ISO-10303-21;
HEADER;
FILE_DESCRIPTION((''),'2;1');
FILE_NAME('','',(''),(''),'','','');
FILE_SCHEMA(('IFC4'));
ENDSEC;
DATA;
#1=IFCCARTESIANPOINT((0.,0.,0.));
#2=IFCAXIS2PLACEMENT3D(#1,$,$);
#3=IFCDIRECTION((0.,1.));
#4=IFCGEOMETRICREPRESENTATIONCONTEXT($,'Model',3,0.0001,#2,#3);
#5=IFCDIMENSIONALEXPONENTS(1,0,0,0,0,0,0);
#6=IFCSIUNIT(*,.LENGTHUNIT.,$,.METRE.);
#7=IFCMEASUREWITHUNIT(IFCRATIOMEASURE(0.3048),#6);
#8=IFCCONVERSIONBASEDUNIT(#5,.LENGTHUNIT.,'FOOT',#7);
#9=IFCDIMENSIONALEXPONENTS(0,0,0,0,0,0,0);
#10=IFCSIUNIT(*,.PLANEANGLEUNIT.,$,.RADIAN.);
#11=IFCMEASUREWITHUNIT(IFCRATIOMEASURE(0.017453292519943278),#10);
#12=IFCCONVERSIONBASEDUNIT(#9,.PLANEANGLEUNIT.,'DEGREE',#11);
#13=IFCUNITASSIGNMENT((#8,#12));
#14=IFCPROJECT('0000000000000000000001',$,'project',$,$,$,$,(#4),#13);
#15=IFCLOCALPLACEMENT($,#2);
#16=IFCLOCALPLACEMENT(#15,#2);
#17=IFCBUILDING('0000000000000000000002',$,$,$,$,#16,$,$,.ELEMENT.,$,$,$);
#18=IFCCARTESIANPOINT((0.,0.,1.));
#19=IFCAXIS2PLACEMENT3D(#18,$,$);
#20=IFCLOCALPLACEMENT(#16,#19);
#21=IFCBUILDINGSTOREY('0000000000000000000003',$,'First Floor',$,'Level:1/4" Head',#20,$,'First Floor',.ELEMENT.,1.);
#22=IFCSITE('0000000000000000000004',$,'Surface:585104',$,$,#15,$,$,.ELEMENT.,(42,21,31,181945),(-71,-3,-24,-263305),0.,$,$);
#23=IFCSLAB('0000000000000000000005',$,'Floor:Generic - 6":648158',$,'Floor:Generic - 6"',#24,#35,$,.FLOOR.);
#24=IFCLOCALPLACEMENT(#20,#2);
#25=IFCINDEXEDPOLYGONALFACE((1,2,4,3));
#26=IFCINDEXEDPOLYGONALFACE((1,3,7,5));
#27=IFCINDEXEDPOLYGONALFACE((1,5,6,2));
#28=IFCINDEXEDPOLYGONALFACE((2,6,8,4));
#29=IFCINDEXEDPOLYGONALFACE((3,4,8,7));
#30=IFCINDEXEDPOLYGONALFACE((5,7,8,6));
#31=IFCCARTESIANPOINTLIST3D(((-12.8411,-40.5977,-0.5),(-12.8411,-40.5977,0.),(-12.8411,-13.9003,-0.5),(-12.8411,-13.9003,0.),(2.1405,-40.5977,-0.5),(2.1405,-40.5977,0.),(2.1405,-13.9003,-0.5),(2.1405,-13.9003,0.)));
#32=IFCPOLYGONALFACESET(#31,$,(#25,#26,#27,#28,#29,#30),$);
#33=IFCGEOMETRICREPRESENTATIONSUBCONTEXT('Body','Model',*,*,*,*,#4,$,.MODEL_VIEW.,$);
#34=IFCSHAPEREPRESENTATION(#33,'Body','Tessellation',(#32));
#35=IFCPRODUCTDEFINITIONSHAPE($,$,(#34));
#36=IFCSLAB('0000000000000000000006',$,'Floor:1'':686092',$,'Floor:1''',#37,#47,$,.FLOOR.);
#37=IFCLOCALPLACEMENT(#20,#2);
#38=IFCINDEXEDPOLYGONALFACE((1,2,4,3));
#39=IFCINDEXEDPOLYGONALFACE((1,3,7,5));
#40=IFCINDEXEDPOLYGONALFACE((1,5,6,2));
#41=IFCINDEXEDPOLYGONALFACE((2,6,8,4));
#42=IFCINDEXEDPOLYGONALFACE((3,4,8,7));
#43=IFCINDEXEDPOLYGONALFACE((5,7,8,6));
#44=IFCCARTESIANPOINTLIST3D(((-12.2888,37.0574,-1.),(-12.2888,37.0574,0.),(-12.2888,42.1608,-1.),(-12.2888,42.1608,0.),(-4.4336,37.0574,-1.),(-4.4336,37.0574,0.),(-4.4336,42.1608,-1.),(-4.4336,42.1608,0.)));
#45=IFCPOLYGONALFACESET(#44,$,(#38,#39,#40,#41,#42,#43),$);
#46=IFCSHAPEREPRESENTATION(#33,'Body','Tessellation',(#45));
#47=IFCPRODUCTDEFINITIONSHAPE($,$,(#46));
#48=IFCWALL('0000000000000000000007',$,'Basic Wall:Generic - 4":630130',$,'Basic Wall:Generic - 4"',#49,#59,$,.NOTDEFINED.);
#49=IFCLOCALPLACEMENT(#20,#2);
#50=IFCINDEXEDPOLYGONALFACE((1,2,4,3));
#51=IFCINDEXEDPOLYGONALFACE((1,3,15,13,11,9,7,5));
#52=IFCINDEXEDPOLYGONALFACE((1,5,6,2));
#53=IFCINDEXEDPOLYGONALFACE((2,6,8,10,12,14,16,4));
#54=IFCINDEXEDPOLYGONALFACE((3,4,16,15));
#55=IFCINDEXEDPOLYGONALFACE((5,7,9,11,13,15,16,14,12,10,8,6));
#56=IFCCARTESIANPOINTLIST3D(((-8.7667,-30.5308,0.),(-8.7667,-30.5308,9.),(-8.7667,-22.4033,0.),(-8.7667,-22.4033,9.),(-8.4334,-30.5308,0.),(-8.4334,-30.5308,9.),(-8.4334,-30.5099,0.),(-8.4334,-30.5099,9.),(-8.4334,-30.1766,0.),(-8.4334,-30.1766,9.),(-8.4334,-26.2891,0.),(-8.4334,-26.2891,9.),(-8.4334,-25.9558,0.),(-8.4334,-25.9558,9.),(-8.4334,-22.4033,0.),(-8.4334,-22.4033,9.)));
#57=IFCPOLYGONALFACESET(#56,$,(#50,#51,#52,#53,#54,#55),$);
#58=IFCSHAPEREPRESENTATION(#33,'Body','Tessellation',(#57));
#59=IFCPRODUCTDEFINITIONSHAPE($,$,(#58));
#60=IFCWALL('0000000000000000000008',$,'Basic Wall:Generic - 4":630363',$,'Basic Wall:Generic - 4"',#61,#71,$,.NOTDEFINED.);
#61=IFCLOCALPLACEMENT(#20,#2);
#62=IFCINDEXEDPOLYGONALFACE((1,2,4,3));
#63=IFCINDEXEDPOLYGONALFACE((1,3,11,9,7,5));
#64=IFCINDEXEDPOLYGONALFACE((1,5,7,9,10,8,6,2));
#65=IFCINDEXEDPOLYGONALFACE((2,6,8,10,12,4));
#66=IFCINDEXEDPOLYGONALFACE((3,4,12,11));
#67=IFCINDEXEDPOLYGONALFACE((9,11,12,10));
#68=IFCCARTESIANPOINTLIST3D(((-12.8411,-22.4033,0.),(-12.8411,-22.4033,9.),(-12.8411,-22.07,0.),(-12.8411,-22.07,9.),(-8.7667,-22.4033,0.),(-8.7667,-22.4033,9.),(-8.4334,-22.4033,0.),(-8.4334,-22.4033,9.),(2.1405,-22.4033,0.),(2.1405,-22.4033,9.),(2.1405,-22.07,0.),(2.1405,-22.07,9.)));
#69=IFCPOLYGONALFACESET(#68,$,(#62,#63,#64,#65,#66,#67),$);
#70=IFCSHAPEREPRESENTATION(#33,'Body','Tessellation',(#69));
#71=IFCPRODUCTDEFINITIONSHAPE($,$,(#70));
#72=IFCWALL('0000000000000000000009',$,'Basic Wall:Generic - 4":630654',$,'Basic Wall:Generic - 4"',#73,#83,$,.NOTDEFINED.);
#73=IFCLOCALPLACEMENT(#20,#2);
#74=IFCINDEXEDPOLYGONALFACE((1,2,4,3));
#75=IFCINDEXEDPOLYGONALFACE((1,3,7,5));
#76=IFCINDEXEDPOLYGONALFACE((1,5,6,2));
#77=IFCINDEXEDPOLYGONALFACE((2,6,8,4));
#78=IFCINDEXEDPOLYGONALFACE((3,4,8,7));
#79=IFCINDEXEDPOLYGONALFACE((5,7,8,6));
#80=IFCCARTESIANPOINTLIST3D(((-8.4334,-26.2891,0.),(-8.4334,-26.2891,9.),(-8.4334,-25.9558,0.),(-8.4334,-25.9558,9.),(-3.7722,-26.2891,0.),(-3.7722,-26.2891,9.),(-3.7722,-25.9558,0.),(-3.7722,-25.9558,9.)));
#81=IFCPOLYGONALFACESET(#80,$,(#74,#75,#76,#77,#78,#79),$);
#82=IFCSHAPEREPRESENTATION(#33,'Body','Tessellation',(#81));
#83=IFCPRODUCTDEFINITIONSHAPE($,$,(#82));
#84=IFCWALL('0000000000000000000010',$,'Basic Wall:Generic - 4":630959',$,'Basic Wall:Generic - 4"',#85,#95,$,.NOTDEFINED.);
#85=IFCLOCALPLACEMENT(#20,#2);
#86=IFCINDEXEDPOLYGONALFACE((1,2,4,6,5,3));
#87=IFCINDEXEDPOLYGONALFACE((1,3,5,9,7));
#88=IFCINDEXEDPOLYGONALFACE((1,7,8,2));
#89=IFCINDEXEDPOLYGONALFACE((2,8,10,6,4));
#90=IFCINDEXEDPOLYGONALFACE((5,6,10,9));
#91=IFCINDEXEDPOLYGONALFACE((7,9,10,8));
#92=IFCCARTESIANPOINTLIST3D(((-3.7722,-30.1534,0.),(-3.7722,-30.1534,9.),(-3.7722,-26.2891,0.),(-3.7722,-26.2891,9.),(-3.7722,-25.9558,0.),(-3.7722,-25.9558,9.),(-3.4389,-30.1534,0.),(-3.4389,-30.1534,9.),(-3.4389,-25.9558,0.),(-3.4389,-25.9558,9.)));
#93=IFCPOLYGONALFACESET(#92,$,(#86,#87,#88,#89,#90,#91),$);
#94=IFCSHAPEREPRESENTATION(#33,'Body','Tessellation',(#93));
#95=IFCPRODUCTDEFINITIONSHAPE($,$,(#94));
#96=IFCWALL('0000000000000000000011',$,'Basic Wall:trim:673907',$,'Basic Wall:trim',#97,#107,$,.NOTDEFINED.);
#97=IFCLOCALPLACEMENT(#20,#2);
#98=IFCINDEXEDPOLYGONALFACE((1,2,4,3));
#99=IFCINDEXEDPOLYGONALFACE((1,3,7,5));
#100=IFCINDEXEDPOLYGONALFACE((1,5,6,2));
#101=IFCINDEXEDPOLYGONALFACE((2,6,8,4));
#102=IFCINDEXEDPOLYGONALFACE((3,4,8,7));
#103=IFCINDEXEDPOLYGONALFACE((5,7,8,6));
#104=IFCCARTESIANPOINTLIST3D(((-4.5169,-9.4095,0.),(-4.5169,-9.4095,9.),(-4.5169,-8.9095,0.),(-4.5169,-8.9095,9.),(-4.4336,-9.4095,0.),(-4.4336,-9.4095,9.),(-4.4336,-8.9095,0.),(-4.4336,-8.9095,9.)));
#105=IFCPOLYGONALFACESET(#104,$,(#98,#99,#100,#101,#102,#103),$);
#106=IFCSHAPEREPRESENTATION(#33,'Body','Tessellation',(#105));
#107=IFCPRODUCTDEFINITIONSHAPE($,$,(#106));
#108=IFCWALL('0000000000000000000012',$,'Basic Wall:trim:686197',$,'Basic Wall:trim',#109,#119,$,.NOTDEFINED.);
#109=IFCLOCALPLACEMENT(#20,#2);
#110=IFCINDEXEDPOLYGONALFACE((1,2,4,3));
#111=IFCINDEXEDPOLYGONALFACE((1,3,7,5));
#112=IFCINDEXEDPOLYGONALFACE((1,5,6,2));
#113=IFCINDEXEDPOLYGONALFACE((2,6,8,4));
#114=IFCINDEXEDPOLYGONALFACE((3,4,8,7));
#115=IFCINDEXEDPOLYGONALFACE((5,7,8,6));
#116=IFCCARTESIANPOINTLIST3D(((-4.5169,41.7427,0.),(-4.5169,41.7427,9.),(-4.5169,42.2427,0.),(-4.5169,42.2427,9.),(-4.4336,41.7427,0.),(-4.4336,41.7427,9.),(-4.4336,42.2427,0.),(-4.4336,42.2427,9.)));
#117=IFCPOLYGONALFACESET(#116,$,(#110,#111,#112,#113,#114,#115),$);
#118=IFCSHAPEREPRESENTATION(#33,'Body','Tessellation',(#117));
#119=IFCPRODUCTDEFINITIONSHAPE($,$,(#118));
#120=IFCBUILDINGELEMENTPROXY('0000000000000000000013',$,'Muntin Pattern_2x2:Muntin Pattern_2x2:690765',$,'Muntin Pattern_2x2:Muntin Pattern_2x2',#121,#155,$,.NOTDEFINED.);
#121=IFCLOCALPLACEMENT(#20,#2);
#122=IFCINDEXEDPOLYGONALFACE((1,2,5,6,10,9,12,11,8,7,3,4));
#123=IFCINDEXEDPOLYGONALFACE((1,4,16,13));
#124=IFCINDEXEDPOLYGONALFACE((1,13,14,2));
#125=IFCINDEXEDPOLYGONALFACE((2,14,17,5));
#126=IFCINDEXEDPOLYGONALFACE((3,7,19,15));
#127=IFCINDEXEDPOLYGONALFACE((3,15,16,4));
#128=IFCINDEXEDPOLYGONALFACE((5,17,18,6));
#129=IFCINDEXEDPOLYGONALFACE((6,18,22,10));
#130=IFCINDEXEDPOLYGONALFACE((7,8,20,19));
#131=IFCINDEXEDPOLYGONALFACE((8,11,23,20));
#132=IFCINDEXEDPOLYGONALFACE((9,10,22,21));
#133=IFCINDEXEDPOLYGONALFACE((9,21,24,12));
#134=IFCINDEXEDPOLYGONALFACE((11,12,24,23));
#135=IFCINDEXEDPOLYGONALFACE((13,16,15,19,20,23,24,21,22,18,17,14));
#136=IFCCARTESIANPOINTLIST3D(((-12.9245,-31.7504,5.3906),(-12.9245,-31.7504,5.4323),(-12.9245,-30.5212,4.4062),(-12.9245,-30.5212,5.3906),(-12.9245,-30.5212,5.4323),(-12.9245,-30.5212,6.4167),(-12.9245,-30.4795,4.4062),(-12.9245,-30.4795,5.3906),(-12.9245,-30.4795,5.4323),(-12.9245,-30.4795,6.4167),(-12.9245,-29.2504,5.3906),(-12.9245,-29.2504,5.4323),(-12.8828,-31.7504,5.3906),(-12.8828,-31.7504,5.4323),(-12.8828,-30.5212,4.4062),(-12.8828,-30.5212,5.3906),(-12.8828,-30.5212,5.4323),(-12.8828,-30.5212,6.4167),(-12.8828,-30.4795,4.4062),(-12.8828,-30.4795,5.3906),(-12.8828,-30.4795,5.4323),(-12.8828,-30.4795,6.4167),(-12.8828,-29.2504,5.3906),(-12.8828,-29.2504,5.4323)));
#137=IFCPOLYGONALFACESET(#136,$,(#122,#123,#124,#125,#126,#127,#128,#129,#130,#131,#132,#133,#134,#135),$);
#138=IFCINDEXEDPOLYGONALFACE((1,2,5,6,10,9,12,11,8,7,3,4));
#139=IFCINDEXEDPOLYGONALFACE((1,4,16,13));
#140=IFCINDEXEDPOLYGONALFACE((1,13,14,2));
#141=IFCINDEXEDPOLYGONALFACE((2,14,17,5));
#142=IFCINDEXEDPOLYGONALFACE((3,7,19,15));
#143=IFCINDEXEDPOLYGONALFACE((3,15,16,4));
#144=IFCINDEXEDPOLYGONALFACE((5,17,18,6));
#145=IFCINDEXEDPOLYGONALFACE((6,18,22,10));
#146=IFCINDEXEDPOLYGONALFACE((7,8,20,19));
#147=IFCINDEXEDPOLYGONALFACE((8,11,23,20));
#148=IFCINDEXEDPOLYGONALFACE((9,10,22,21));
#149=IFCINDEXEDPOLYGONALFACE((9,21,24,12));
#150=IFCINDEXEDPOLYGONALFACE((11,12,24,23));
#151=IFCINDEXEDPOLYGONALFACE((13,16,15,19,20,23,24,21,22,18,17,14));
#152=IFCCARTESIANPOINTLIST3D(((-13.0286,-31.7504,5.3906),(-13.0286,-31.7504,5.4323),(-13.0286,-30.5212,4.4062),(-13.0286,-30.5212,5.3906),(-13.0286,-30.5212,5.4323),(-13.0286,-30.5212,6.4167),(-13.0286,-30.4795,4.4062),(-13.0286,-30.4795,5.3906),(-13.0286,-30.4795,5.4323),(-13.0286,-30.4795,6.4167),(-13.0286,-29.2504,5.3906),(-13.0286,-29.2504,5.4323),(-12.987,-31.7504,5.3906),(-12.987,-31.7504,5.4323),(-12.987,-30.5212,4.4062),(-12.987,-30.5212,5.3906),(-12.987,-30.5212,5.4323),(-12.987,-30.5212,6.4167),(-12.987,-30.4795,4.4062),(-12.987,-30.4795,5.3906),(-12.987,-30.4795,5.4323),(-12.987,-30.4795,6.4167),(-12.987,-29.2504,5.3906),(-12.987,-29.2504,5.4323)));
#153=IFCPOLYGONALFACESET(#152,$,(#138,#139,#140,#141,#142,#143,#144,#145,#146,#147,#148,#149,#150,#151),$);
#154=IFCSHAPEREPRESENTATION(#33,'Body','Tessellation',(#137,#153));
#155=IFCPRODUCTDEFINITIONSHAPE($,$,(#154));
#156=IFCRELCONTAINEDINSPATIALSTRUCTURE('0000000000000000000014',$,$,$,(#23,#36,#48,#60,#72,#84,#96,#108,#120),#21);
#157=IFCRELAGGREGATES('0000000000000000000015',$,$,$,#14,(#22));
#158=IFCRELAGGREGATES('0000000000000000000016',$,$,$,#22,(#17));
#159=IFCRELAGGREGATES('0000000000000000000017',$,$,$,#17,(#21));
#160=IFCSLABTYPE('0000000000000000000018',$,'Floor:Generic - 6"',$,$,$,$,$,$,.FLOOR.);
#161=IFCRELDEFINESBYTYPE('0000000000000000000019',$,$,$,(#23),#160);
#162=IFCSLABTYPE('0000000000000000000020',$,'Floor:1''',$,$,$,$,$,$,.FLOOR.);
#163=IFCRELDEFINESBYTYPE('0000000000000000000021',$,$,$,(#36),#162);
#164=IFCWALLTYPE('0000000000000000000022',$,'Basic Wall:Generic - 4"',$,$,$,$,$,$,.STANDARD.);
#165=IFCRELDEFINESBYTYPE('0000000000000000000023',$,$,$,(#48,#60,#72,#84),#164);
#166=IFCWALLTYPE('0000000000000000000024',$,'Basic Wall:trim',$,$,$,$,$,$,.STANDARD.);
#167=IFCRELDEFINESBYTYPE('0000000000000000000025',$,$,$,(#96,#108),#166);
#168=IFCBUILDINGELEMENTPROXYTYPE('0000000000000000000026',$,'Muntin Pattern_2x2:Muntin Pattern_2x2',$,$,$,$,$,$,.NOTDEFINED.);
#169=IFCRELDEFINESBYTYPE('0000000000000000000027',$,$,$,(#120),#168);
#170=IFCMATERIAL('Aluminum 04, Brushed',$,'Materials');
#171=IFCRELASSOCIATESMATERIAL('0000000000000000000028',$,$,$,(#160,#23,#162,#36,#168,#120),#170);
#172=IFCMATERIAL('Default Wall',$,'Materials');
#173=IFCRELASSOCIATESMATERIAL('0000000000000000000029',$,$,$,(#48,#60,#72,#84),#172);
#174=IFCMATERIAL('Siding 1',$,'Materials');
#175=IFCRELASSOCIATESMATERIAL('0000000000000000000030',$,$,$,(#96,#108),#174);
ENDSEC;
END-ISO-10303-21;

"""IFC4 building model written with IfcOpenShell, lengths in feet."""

from ifc_helpers import new_model, entity, si_unit, converted_unit, direction, frame, origin, place, context, subcontext, project, spatial, indexed_curve, outline, extrude, source, transform, mapped, material, type_object, type_shapes, element, save


model = new_model("IFC4")

# Units and contexts
model_context = context("Model", 3, precision=0.0001, world=origin(), true_north=direction((0.0, 1.0)))
body_context = subcontext(model_context, "Body", "Model", "MODEL_VIEW")
ifc_project = project(units=[converted_unit("LENGTHUNIT", "FOOT", entity("IfcRatioMeasure", 0.3048), si_unit("LENGTHUNIT", "METRE"), dimensions=[1, 0, 0, 0, 0, 0, 0]), converted_unit("PLANEANGLEUNIT", "DEGREE", entity("IfcRatioMeasure", 0.017453292519943278), si_unit("PLANEANGLEUNIT", "RADIAN"), dimensions=[0, 0, 0, 0, 0, 0, 0])], contexts=[model_context])

# Site, building, storey
site_placement = place(None, origin())
site = spatial("IfcSite", under=ifc_project, at=site_placement, Name="Surface:585104", CompositionType="ELEMENT", RefLatitude=(42, 21, 31, 181945), RefLongitude=(-71, -3, -24, -263305), RefElevation=0.0)
building_placement = place(site_placement, origin())
building = spatial("IfcBuilding", under=site, at=building_placement, CompositionType="ELEMENT")
storey_placement = place(building_placement, frame((0.0, 0.0, 1.0)))
storey = spatial("IfcBuildingStorey", under=building, at=storey_placement, Name="First Floor", ObjectType="Level:1/4\" Head", LongName="First Floor", CompositionType="ELEMENT", Elevation=1.0)

# Shared definitions
ifc_material_1 = material(Name="Aluminum 04, Brushed", Category="Materials")

# Slabs
slab_type_1 = type_object("IfcSlabType", Name="Floor:Generic - 6\"", PredefinedType="FLOOR", material=ifc_material_1)
slab_1_placement = place(storey_placement, origin())
element("IfcSlab", 1, at=slab_1_placement, inside=storey, type_object=slab_type_1, material=ifc_material_1, Name="Floor:Generic - 6\":648158", ObjectType="Floor:Generic - 6\"", PredefinedType="FLOOR", context=body_context, shape_type="SweptSolid", body=[
    extrude(outline(indexed_curve([(-13.3487, -7.4908), (13.3487, -7.4908), (13.3487, 7.4908), (-13.3487, 7.4908), (-13.3487, -7.4908)], self_intersect=False)), frame((-5.3503, -27.249, 0.0), z_axis=(0.0, 0.0, -1.0), x_axis=(0.0, 1.0, 0.0)), (0.0, 0.0, 1.0), 0.5),
])
slab_type_2 = type_object("IfcSlabType", Name="Floor:1'", PredefinedType="FLOOR", material=ifc_material_1)
slab_2_placement = place(storey_placement, origin())
element("IfcSlab", 2, at=slab_2_placement, inside=storey, type_object=slab_type_2, material=ifc_material_1, Name="Floor:1':686092", ObjectType="Floor:1'", PredefinedType="FLOOR", context=body_context, shape_type="SweptSolid", body=[
    extrude(outline(indexed_curve([(-2.5517, -3.9276), (2.5517, -3.9276), (2.5517, 3.9276), (-2.5517, 3.9276), (-2.5517, -3.9276)], self_intersect=False)), frame((-8.3612, 39.6091, 0.0), z_axis=(0.0, 0.0, -1.0), x_axis=(0.0, 1.0, 0.0)), (0.0, 0.0, 1.0), 1.0),
])

# Walls
ifc_material_2 = material(Name="Default Wall", Category="Materials")
wall_type_1 = type_object("IfcWallType", Name="Basic Wall:Generic - 4\"", PredefinedType="STANDARD")
wall_1_placement = place(storey_placement, frame((-8.6001, -30.5308, 0.0), z_axis=(0.0, 0.0, 1.0), x_axis=(0.0, 1.0, 0.0)))
element("IfcWall", 3, at=wall_1_placement, inside=storey, type_object=wall_type_1, material=ifc_material_2, Name="Basic Wall:Generic - 4\":630130", ObjectType="Basic Wall:Generic - 4\"", PredefinedType="NOTDEFINED", context=body_context, shape_type="SweptSolid", body=[
    extrude(outline(indexed_curve([(8.1274, -0.1667), (8.1274, 0.1667), (0.0, 0.1667), (0.0, -0.1667), (0.0208, -0.1667), (0.3542, -0.1667), (4.2416, -0.1667), (4.575, -0.1667), (8.1274, -0.1667)], self_intersect=False)), origin(), (0.0, 0.0, 1.0), 9.0),
])
wall_2_placement = place(storey_placement, frame((-12.8411, -22.2367, 0.0)))
element("IfcWall", 4, at=wall_2_placement, inside=storey, type_object=wall_type_1, material=ifc_material_2, Name="Basic Wall:Generic - 4\":630363", ObjectType="Basic Wall:Generic - 4\"", PredefinedType="NOTDEFINED", context=body_context, shape_type="SweptSolid", body=[
    extrude(outline(indexed_curve([(14.9816, -0.1667), (14.9816, 0.1667), (0.0, 0.1667), (0.0, -0.1667), (4.0744, -0.1667), (4.4077, -0.1667), (14.9816, -0.1667)], self_intersect=False)), origin(), (0.0, 0.0, 1.0), 9.0),
])
wall_3_placement = place(storey_placement, frame((-8.4334, -26.1225, 0.0)))
element("IfcWall", 5, at=wall_3_placement, inside=storey, type_object=wall_type_1, material=ifc_material_2, Name="Basic Wall:Generic - 4\":630654", ObjectType="Basic Wall:Generic - 4\"", PredefinedType="NOTDEFINED", context=body_context, shape_type="SweptSolid", body=[
    extrude(outline(indexed_curve([(4.6612, -0.1667), (4.6612, 0.1667), (0.0, 0.1667), (0.0, -0.1667), (4.6612, -0.1667)], self_intersect=False)), origin(), (0.0, 0.0, 1.0), 9.0),
])
wall_4_placement = place(storey_placement, frame((-3.6055, -25.9558, 0.0), z_axis=(0.0, 0.0, 1.0), x_axis=(0.0, -1.0, 0.0)))
element("IfcWall", 6, at=wall_4_placement, inside=storey, type_object=wall_type_1, material=ifc_material_2, Name="Basic Wall:Generic - 4\":630959", ObjectType="Basic Wall:Generic - 4\"", PredefinedType="NOTDEFINED", context=body_context, shape_type="SweptSolid", body=[
    extrude(outline(indexed_curve([(4.1976, -0.1667), (4.1976, 0.1667), (0.0, 0.1667), (0.0, -0.1667), (0.3333, -0.1667), (4.1976, -0.1667)], self_intersect=False)), origin(), (0.0, 0.0, 1.0), 9.0),
])
ifc_material_3 = material(Name="Siding 1", Category="Materials")
wall_type_2 = type_object("IfcWallType", Name="Basic Wall:trim", PredefinedType="STANDARD")
wall_5_placement = place(storey_placement, frame((-4.4752, -9.4095, 0.0), z_axis=(0.0, 0.0, 1.0), x_axis=(0.0, 1.0, 0.0)))
element("IfcWall", 7, at=wall_5_placement, inside=storey, type_object=wall_type_2, material=ifc_material_3, Name="Basic Wall:trim:673907", ObjectType="Basic Wall:trim", PredefinedType="NOTDEFINED", context=body_context, shape_type="SweptSolid", body=[
    extrude(outline(indexed_curve([(0.5, -0.0417), (0.5, 0.0417), (0.0, 0.0417), (0.0, -0.0417), (0.5, -0.0417)], self_intersect=False)), origin(), (0.0, 0.0, 1.0), 9.0),
])
wall_6_placement = place(storey_placement, frame((-4.4752, 42.2427, 0.0), z_axis=(0.0, 0.0, 1.0), x_axis=(0.0, -1.0, 0.0)))
element("IfcWall", 8, at=wall_6_placement, inside=storey, type_object=wall_type_2, material=ifc_material_3, Name="Basic Wall:trim:686197", ObjectType="Basic Wall:trim", PredefinedType="NOTDEFINED", context=body_context, shape_type="SweptSolid", body=[
    extrude(outline(indexed_curve([(0.5, -0.0417), (0.5, 0.0417), (0.0, 0.0417), (0.0, -0.0417), (0.5, -0.0417)], self_intersect=False)), origin(), (0.0, 0.0, 1.0), 9.0),
])

# Building element proxy
building_element_proxy_type_1 = type_object("IfcBuildingElementProxyType", Name="Muntin Pattern_2x2:Muntin Pattern_2x2", PredefinedType="NOTDEFINED", material=ifc_material_1)
shared_shape_1 = source(origin(), body_context, "Body", "SweptSolid", [
    extrude(outline(indexed_curve([(0.0208, -0.0208), (1.0052, -0.0208), (1.0052, 0.0208), (0.0208, 0.0208), (0.0208, 1.25), (-0.0208, 1.25), (-0.0208, 0.0208), (-1.0052, 0.0208), (-1.0052, -0.0208), (-0.0208, -0.0208), (-0.0208, -1.25), (0.0208, -1.25), (0.0208, -0.0208)], self_intersect=False)), frame((0.0, 0.0312, 1.0052), z_axis=(0.0, 1.0, 0.0), x_axis=(0.0, 0.0, 1.0)), (0.0, 0.0, 1.0), 0.0417),
    extrude(outline(indexed_curve([(0.0208, -0.0208), (1.0052, -0.0208), (1.0052, 0.0208), (0.0208, 0.0208), (0.0208, 1.25), (-0.0208, 1.25), (-0.0208, 0.0208), (-1.0052, 0.0208), (-1.0052, -0.0208), (-0.0208, -0.0208), (-0.0208, -1.25), (0.0208, -1.25), (0.0208, -0.0208)], self_intersect=False)), frame((0.0, -0.0729, 1.0052), z_axis=(0.0, 1.0, 0.0), x_axis=(0.0, 0.0, 1.0)), (0.0, 0.0, 1.0), 0.0417),
])
type_shapes(building_element_proxy_type_1, [shared_shape_1])
for number, where, z_axis, x_axis, name in (
    (9, (-12.9557, -30.5004, 4.4062), (0.0, 0.0, 1.0), (0.0, -1.0, 0.0), "Muntin Pattern_2x2:Muntin Pattern_2x2:690765"),
):
    element("IfcBuildingElementProxy", number, at=place(storey_placement, frame(where, z_axis=z_axis, x_axis=x_axis)), inside=storey, type_object=building_element_proxy_type_1, material=ifc_material_1, Name=name, ObjectType="Muntin Pattern_2x2:Muntin Pattern_2x2", PredefinedType="NOTDEFINED", context=body_context, shape_type="MappedRepresentation", body=[
        mapped(shared_shape_1, transform((0.0, 0.0, 0.0), scale=1.0)),
    ])

save(model, "model.ifc")
